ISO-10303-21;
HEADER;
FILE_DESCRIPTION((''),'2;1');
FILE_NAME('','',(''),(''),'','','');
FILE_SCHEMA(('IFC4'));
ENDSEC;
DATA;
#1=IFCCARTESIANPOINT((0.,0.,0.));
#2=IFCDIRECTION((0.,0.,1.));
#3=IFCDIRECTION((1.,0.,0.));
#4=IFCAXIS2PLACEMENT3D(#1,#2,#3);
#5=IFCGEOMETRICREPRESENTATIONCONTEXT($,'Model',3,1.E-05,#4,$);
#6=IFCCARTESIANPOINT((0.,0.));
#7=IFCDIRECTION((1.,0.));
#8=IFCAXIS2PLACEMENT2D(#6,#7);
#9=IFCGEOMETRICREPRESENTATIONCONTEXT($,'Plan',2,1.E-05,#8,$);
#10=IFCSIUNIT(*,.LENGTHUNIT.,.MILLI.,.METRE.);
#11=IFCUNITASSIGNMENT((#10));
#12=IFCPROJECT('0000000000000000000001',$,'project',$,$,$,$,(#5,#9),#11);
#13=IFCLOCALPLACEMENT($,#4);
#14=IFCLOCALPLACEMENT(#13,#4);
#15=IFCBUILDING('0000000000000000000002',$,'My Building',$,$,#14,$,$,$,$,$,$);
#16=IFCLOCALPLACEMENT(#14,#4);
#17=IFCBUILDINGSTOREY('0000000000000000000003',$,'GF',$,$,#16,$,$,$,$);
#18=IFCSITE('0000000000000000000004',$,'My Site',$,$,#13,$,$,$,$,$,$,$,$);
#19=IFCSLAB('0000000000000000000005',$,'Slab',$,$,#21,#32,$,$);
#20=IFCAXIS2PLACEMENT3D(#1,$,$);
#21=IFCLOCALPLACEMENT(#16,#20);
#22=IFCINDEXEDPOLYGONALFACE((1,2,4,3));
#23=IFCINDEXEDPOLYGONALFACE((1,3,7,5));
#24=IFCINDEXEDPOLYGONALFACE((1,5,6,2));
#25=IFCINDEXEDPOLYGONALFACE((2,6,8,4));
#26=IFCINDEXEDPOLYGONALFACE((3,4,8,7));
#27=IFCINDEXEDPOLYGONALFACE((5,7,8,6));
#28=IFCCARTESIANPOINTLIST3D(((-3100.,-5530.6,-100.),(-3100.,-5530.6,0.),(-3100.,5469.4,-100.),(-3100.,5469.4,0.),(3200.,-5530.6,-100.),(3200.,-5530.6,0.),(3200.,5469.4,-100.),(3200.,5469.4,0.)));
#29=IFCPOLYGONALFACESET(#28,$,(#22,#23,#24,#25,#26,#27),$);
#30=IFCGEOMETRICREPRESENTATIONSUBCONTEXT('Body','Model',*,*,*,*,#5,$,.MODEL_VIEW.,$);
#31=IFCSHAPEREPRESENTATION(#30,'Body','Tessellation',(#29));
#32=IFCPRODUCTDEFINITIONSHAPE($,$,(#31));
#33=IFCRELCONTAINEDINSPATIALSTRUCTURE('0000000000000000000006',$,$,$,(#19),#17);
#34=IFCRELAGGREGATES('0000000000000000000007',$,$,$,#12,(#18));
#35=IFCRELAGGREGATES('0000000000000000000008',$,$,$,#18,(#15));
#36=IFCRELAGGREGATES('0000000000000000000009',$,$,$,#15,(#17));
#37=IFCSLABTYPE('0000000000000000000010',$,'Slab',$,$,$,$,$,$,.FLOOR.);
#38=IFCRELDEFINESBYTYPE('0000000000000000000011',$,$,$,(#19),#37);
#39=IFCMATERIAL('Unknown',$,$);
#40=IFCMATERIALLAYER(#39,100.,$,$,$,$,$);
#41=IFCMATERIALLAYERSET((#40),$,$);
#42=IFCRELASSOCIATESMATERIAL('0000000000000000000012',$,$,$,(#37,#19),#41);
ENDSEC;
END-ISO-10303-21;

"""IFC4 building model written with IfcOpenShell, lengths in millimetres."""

from ifc_helpers import new_model, si_unit, frame, origin_with_axes, origin_2d_with_axis, place, context, subcontext, project, spatial, indexed_curve, outline, extrude, material, layer, layer_set, layer_usage, type_object, element, save


model = new_model("IFC4")

# Units and contexts
model_context = context("Model", 3, precision=1e-05, world=origin_with_axes())
plan_context = context("Plan", 2, precision=1e-05, world=origin_2d_with_axis())
body_context_1 = subcontext(model_context, "Body", "Model", "MODEL_VIEW")
ifc_project = project(units=[si_unit("LENGTHUNIT", "METRE", prefix="MILLI")], contexts=[model_context, plan_context])

# Site, building, storey
site_placement = place(None, origin_with_axes())
site = spatial("IfcSite", under=ifc_project, at=site_placement, Name="My Site")
building_placement = place(site_placement, origin_with_axes())
building = spatial("IfcBuilding", under=site, at=building_placement, Name="My Building")
storey_placement = place(building_placement, origin_with_axes())
storey = spatial("IfcBuildingStorey", under=building, at=storey_placement, Name="GF")

# Slab
ifc_material = material(Name="Unknown")
ifc_layer_1 = layer(ifc_material, 100.0)
ifc_layer_set_1 = layer_set([ifc_layer_1])
ifc_layer_usage_1 = layer_usage(ifc_layer_set_1, "AXIS3", "POSITIVE", -100.0)
slab_type = type_object("IfcSlabType", Name="Slab", PredefinedType="FLOOR", material=ifc_layer_set_1)
slab_placement = place(storey_placement, frame((-3100.0, 5469.4, 0.0), z_axis=(0.0, 0.0, 1.0), x_axis=(1.0, 0.0, 0.0)))
element("IfcSlab", 1, at=slab_placement, inside=storey, type_object=slab_type, material=ifc_layer_usage_1, Name="Slab", context=body_context_1, shape_type="SweptSolid", body=[
    extrude(outline(indexed_curve([(0.0, 0.0), (6300.0, 0.0), (6300.0, -11000.0), (0.0, -11000.0), (0.0, 0.0)])), frame((0.0, 0.0, -100.0), z_axis=(0.0, 0.0, 1.0), x_axis=(1.0, 0.0, 0.0)), (0.0, 0.0, 1.0), 100.0),
])

save(model, "model.ifc")
